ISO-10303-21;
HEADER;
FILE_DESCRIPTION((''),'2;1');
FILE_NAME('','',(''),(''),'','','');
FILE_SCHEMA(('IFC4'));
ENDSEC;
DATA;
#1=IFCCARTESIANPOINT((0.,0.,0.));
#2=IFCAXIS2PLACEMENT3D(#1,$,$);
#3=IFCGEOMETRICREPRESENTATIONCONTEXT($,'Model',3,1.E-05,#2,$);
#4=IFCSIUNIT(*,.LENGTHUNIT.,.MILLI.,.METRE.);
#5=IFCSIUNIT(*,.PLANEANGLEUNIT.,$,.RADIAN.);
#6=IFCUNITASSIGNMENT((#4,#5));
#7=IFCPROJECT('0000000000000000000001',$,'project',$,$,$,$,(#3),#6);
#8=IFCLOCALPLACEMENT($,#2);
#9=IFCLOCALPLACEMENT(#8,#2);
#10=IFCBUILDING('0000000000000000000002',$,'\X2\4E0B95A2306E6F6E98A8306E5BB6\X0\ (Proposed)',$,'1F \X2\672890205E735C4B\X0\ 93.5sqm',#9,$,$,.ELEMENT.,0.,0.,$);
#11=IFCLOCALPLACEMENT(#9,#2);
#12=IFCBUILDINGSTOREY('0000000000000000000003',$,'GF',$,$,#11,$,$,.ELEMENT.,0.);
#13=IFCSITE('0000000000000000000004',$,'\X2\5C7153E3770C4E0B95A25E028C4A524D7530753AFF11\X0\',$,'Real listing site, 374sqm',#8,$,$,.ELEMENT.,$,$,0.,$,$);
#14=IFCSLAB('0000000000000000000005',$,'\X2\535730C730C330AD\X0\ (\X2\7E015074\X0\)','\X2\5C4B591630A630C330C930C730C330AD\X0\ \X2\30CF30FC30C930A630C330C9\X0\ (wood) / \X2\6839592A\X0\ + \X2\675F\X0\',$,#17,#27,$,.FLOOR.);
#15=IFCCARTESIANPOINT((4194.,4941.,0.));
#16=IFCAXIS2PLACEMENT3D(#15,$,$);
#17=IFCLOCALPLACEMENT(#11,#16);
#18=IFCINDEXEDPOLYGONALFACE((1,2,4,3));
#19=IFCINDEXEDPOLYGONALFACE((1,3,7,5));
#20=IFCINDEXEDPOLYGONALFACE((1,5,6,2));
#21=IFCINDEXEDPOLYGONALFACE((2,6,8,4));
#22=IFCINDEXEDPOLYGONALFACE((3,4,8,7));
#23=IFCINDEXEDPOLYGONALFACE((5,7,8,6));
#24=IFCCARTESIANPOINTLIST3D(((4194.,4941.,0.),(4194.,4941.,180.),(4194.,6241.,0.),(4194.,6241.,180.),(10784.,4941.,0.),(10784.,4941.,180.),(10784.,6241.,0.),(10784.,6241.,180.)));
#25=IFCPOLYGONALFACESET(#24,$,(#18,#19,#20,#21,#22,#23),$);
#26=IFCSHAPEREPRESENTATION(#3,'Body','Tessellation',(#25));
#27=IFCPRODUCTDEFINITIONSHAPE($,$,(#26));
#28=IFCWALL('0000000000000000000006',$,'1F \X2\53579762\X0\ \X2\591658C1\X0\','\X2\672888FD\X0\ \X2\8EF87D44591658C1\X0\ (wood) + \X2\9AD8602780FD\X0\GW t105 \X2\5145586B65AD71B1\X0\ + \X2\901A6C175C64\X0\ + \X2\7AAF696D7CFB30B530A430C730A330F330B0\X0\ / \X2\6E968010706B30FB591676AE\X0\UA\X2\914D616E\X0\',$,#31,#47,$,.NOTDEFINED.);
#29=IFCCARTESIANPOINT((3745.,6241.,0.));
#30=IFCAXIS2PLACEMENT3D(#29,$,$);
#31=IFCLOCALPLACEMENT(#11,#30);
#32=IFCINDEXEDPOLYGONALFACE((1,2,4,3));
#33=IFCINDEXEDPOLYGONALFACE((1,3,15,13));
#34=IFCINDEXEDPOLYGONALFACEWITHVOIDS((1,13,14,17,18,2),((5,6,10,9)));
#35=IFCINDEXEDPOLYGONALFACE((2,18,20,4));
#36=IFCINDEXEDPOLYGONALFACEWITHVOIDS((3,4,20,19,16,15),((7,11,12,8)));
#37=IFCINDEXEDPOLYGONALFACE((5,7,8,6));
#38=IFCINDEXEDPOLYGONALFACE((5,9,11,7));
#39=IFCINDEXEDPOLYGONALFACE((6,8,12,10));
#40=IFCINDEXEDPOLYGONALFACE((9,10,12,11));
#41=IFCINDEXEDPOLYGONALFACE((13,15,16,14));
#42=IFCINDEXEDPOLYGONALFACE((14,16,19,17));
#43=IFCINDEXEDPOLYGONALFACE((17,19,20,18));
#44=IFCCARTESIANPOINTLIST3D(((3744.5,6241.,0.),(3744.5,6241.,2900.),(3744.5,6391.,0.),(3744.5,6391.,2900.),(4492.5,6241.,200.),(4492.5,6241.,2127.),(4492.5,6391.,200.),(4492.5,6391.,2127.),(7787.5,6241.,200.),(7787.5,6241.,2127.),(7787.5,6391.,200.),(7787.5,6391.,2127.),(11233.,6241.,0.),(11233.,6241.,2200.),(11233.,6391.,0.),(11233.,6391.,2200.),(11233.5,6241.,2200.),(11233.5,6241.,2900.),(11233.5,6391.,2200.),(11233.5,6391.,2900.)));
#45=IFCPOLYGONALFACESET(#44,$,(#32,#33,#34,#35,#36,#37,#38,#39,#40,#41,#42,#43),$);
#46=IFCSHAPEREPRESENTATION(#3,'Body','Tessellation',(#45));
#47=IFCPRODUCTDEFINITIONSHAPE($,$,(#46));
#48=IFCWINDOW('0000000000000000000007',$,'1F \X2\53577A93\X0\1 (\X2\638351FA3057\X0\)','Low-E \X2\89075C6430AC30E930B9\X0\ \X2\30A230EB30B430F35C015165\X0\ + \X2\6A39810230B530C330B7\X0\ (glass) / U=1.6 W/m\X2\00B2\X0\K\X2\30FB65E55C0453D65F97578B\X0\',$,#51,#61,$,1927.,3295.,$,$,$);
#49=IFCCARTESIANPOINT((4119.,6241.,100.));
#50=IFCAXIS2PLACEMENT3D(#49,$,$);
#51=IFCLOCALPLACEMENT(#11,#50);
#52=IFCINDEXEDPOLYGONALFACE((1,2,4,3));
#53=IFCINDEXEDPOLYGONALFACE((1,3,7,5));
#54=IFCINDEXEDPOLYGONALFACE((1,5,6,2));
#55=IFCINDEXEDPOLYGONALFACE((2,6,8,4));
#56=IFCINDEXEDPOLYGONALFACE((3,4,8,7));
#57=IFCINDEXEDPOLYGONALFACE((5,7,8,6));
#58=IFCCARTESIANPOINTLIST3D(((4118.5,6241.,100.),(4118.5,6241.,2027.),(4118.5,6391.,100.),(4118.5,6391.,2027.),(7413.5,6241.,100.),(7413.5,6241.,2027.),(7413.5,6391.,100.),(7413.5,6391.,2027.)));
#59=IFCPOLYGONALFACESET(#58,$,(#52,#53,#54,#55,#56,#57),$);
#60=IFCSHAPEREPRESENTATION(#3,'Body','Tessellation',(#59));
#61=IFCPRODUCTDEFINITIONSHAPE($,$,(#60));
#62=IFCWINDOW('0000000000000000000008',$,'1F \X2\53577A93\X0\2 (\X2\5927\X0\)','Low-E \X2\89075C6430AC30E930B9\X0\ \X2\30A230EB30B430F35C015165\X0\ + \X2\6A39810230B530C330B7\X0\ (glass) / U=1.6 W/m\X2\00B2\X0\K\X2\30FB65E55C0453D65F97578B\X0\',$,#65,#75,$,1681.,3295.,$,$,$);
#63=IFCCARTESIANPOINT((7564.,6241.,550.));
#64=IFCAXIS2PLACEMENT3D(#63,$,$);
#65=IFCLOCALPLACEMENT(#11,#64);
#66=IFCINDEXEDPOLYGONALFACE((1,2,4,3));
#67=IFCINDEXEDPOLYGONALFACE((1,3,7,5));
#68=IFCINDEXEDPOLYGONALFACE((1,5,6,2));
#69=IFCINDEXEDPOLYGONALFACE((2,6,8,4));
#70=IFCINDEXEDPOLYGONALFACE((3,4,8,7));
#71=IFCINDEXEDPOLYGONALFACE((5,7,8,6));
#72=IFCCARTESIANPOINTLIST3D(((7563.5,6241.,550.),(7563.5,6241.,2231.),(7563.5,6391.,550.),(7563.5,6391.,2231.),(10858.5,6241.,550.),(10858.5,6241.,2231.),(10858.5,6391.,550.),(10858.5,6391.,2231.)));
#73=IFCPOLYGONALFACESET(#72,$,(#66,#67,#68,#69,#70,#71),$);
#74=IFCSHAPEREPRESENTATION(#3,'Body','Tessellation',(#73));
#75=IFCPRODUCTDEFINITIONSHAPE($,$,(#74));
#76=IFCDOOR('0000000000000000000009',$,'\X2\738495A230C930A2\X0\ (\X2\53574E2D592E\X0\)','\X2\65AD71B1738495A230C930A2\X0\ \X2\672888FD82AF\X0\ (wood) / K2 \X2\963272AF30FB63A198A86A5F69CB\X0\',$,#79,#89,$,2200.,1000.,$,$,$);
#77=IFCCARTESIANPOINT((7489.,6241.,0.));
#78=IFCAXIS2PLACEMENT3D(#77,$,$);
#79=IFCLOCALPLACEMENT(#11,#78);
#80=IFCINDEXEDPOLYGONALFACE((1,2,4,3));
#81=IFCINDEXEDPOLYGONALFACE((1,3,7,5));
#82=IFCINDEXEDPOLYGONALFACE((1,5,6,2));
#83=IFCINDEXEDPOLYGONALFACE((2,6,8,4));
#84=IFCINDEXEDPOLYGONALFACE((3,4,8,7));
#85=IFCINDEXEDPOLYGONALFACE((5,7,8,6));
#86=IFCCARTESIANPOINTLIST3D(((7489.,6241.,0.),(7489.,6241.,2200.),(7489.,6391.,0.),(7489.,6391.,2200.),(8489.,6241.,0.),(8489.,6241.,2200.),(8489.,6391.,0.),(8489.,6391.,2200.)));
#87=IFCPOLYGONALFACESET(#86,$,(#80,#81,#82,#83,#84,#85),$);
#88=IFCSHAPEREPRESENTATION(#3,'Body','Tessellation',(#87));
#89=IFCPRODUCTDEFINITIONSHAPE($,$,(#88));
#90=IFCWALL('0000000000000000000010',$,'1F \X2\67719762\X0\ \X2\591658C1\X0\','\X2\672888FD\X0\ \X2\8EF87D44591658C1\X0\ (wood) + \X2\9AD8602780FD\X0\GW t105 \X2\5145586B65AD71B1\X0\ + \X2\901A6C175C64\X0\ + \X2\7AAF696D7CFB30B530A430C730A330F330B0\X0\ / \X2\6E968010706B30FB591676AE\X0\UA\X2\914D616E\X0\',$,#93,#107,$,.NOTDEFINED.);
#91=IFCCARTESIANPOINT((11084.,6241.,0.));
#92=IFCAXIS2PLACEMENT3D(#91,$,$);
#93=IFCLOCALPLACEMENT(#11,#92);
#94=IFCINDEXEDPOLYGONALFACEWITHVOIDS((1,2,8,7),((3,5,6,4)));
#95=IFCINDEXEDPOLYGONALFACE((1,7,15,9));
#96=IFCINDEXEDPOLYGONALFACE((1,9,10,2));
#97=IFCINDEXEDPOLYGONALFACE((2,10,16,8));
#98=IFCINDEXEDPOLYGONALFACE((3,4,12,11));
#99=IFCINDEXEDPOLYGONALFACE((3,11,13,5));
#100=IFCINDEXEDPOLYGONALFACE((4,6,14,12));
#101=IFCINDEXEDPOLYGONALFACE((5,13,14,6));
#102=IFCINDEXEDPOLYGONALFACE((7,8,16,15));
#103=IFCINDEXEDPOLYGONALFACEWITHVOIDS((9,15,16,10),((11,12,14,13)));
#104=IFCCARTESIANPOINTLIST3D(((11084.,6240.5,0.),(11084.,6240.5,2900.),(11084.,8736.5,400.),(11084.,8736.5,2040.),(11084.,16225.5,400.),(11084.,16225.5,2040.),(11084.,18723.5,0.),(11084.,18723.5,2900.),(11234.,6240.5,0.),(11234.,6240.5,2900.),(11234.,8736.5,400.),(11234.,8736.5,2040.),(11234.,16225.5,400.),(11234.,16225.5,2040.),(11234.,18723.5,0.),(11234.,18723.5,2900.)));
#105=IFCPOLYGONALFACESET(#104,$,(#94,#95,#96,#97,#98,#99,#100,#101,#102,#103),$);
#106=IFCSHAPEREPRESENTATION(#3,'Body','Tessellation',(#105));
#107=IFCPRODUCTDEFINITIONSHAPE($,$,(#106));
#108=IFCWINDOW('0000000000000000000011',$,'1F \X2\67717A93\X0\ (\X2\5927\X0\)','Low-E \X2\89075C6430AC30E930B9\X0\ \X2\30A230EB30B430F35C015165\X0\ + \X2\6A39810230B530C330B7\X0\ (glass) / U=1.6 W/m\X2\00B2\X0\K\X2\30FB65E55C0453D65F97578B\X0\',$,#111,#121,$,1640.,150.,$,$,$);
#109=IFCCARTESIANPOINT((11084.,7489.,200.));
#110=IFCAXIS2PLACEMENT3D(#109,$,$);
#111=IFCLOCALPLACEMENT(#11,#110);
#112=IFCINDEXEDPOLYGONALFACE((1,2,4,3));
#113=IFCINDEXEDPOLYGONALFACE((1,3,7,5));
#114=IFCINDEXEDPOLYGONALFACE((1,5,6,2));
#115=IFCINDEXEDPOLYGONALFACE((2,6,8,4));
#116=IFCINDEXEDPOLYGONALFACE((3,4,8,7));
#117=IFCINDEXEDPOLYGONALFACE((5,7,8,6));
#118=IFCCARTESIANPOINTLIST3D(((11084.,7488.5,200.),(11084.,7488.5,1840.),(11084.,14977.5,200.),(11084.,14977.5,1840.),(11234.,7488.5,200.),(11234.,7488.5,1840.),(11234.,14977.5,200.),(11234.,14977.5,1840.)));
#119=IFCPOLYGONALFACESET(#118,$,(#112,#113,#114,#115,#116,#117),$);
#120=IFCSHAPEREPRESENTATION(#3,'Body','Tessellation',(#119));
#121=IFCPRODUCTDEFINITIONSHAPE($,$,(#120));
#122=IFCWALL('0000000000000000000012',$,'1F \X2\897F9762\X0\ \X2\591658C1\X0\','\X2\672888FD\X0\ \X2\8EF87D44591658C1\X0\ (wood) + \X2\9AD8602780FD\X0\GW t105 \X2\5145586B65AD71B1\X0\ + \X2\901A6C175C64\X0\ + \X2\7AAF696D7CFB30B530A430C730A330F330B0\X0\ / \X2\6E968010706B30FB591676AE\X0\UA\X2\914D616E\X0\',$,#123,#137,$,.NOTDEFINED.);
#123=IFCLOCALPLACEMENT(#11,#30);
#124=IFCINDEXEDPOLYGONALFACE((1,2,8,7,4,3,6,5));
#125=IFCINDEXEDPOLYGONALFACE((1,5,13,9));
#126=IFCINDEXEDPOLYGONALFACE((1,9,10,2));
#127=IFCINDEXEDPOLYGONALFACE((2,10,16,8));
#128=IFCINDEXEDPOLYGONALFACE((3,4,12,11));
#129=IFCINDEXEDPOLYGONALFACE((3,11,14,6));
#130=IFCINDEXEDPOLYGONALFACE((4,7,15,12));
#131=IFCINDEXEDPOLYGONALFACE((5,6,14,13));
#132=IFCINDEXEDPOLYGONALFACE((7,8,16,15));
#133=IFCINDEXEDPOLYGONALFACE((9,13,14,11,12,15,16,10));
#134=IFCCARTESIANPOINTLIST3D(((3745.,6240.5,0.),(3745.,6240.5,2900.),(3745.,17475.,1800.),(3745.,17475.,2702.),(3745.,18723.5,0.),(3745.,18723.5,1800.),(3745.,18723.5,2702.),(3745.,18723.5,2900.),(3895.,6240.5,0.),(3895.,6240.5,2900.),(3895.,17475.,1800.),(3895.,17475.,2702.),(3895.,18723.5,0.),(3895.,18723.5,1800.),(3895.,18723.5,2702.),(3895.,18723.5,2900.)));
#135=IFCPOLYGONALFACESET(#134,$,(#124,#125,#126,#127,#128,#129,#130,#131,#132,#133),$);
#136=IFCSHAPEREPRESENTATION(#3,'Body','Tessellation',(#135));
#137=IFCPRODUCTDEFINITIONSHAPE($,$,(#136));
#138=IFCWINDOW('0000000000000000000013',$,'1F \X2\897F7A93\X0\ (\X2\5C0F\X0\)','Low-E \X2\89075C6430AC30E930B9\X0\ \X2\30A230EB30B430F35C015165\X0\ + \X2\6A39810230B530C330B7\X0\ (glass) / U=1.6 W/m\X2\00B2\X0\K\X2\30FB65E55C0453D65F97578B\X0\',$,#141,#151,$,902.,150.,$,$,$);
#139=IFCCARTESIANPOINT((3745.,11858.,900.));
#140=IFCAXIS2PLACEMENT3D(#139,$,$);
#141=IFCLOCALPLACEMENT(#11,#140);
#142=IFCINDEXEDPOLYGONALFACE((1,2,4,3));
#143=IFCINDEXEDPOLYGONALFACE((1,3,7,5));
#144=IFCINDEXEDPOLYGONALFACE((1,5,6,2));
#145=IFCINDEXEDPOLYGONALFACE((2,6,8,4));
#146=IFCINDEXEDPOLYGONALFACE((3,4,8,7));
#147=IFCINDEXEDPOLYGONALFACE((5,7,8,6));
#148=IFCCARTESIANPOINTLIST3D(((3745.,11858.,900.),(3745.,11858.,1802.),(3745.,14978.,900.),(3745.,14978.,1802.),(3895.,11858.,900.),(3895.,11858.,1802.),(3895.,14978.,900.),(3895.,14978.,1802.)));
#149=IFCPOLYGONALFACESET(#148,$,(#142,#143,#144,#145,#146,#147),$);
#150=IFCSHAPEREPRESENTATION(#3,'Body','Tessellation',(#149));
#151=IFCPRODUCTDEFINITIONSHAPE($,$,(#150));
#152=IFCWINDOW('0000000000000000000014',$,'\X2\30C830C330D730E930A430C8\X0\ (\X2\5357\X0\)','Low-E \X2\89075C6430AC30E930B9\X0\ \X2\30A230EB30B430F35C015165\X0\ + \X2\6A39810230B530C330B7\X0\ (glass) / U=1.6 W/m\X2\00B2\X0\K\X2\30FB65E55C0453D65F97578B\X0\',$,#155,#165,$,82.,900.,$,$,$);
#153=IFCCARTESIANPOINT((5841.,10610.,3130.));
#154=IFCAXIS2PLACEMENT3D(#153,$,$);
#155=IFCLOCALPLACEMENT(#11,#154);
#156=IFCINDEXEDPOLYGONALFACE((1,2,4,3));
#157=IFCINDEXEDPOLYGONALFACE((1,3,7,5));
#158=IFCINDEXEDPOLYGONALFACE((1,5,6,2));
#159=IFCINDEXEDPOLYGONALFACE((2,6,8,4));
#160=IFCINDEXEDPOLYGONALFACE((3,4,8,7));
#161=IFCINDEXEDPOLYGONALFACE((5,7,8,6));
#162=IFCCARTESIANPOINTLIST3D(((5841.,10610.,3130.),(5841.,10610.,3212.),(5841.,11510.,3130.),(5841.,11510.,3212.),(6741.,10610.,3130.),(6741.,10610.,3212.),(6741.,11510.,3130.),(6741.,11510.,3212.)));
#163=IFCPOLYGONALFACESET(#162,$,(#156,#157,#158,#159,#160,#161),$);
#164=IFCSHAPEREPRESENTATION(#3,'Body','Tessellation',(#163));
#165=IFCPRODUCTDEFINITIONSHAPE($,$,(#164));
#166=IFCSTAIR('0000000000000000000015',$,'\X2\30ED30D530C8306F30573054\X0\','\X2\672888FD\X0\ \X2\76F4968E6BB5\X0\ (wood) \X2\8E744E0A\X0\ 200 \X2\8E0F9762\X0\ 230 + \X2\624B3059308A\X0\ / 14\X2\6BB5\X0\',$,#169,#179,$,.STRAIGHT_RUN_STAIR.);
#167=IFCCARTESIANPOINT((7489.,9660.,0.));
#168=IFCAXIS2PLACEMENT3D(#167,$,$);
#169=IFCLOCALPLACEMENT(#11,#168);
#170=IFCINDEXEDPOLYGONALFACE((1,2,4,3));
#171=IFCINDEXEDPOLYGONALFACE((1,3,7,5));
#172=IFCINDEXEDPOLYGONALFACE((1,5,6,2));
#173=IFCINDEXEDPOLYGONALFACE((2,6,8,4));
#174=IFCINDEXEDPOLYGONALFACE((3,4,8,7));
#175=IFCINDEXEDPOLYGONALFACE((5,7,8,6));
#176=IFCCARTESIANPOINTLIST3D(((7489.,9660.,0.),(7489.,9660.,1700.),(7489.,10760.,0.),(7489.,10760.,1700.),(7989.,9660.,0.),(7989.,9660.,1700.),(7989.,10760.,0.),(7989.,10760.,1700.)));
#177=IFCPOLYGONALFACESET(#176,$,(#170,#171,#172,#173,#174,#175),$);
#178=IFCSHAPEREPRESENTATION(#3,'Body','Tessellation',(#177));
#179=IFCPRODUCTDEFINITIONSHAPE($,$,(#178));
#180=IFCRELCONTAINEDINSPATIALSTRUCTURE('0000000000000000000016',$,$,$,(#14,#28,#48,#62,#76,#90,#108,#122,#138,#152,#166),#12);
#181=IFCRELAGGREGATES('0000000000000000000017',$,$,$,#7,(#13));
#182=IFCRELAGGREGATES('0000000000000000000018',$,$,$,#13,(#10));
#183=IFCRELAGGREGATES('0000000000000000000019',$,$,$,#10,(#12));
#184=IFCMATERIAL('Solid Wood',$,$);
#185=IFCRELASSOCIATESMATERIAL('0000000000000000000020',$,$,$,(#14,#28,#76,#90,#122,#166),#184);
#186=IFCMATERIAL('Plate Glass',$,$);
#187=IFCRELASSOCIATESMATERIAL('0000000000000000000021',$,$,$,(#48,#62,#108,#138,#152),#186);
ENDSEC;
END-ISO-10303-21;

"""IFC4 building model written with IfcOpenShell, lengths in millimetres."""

from ifc_helpers import new_model, si_unit, frame, frame_2d, origin, place, context, project, spatial, rectangle, extrude, material, element, fill, save


model = new_model("IFC4")

# Units and contexts
model_context = context("Model", 3, precision=1e-05, world=origin())
ifc_project = project(units=[si_unit("LENGTHUNIT", "METRE", prefix="MILLI"), si_unit("PLANEANGLEUNIT", "RADIAN")], contexts=[model_context])

# Site, building, storey
site_placement = place(None, origin())
site = spatial("IfcSite", under=ifc_project, at=site_placement, Name="山口県下関市豊前田町１", ObjectType="Real listing site, 374sqm", CompositionType="ELEMENT", RefElevation=0.0)
building_placement = place(site_placement, origin())
building = spatial("IfcBuilding", under=site, at=building_placement, Name="下関の潮風の家 (Proposed)", ObjectType="1F 木造平屋 93.5sqm", CompositionType="ELEMENT", ElevationOfRefHeight=0.0, ElevationOfTerrain=0.0)
storey_placement = place(building_placement, origin())
storey = spatial("IfcBuildingStorey", under=building, at=storey_placement, Name="GF", CompositionType="ELEMENT", Elevation=0.0)

# Slab
ifc_material_1 = material(Name="Solid Wood")
slab_1_placement = place(storey_placement, frame((4194.0, 4941.0, 0.0)))
element("IfcSlab", 1, at=slab_1_placement, inside=storey, material=ifc_material_1, Name="南デッキ (縁側)", Description="屋外ウッドデッキ ハードウッド (wood) / 根太 + 束", PredefinedType="FLOOR", context=model_context, shape_type="SweptSolid", body=[
    extrude(rectangle(XDim=6590.0, YDim=1300.0, at=frame_2d((3295.0, 650.0))), frame((4194.0, 4941.0, 0.0)), (0.0, 0.0, 1.0), 180.0),
])

# Wall, openings, windows, door
wall_1_placement = place(storey_placement, frame((3745.0, 6241.0, 0.0)))
wall_1 = element("IfcWall", 2, at=wall_1_placement, inside=storey, material=ifc_material_1, Name="1F 南面 外壁", Description="木製 軸組外壁 (wood) + 高性能GW t105 充填断熱 + 通気層 + 窯業系サイディング / 準耐火・外皮UA配慮", PredefinedType="NOTDEFINED", context=model_context, shape_type="SweptSolid", body=[
    extrude(rectangle(XDim=7489.0, YDim=150.0, at=frame_2d((3744.0, 75.0))), frame((3745.0, 6241.0, 0.0)), (0.0, 0.0, 1.0), 2900.0),
])
opening_1_placement = place(storey_placement, frame((4119.0, 6241.0, 100.0)))
opening_1 = element("IfcOpeningElement", 3, at=opening_1_placement, cuts=wall_1, PredefinedType="NOTDEFINED", context=model_context, shape_type="SweptSolid", body=[
    extrude(rectangle(XDim=3295.0, YDim=150.0, at=frame_2d((1647.0, 75.0))), frame((4119.0, 6241.0, 100.0)), (0.0, 0.0, 1.0), 1927.0),
])
opening_2_placement = place(storey_placement, frame((7564.0, 6241.0, 550.0)))
opening_2 = element("IfcOpeningElement", 4, at=opening_2_placement, cuts=wall_1, PredefinedType="NOTDEFINED", context=model_context, shape_type="SweptSolid", body=[
    extrude(rectangle(XDim=3295.0, YDim=150.0, at=frame_2d((1647.0, 75.0))), frame((7564.0, 6241.0, 550.0)), (0.0, 0.0, 1.0), 1681.0),
])
opening_3_placement = place(storey_placement, frame((7489.0, 6241.0, 0.0)))
opening_3 = element("IfcOpeningElement", 5, at=opening_3_placement, cuts=wall_1, PredefinedType="NOTDEFINED", context=model_context, shape_type="SweptSolid", body=[
    extrude(rectangle(XDim=1000.0, YDim=150.0, at=frame_2d((500.0, 75.0))), frame((7489.0, 6241.0, 0.0)), (0.0, 0.0, 1.0), 2200.0),
])
ifc_material_2 = material(Name="Plate Glass")
window_1_placement = place(storey_placement, frame((4119.0, 6241.0, 100.0)))
window_1 = element("IfcWindow", 6, at=window_1_placement, inside=storey, material=ifc_material_2, Name="1F 南窓1 (掃出し)", Description="Low-E 複層ガラス アルゴン封入 + 樹脂サッシ (glass) / U=1.6 W/m²K・日射取得型", OverallHeight=1927.0, OverallWidth=3295.0, context=model_context, shape_type="SweptSolid", body=[
    extrude(rectangle(XDim=3295.0, YDim=150.0, at=frame_2d((1647.0, 75.0))), frame((4119.0, 6241.0, 100.0)), (0.0, 0.0, 1.0), 1927.0),
])
fill(opening_1, window_1)
window_2_placement = place(storey_placement, frame((7564.0, 6241.0, 550.0)))
window_2 = element("IfcWindow", 7, at=window_2_placement, inside=storey, material=ifc_material_2, Name="1F 南窓2 (大)", Description="Low-E 複層ガラス アルゴン封入 + 樹脂サッシ (glass) / U=1.6 W/m²K・日射取得型", OverallHeight=1681.0, OverallWidth=3295.0, context=model_context, shape_type="SweptSolid", body=[
    extrude(rectangle(XDim=3295.0, YDim=150.0, at=frame_2d((1647.0, 75.0))), frame((7564.0, 6241.0, 550.0)), (0.0, 0.0, 1.0), 1681.0),
])
fill(opening_2, window_2)
door_placement = place(storey_placement, frame((7489.0, 6241.0, 0.0)))
door = element("IfcDoor", 8, at=door_placement, inside=storey, material=ifc_material_1, Name="玄関ドア (南中央)", Description="断熱玄関ドア 木製芯 (wood) / K2 防犯・採風機構", OverallHeight=2200.0, OverallWidth=1000.0, context=model_context, shape_type="SweptSolid", body=[
    extrude(rectangle(XDim=1000.0, YDim=150.0, at=frame_2d((500.0, 75.0))), frame((7489.0, 6241.0, 0.0)), (0.0, 0.0, 1.0), 2200.0),
])
fill(opening_3, door)

# Walls, openings, windows
wall_2_placement = place(storey_placement, frame((11084.0, 6241.0, 0.0)))
wall_2 = element("IfcWall", 9, at=wall_2_placement, inside=storey, material=ifc_material_1, Name="1F 東面 外壁", Description="木製 軸組外壁 (wood) + 高性能GW t105 充填断熱 + 通気層 + 窯業系サイディング / 準耐火・外皮UA配慮", PredefinedType="NOTDEFINED", context=model_context, shape_type="SweptSolid", body=[
    extrude(rectangle(XDim=150.0, YDim=12483.0, at=frame_2d((75.0, 6241.0))), frame((11084.0, 6241.0, 0.0)), (0.0, 0.0, 1.0), 2900.0),
])
opening_4_placement = place(storey_placement, frame((11084.0, 7489.0, 200.0)))
opening_4 = element("IfcOpeningElement", 10, at=opening_4_placement, cuts=wall_2, PredefinedType="NOTDEFINED", context=model_context, shape_type="SweptSolid", body=[
    extrude(rectangle(XDim=150.0, YDim=7489.0, at=frame_2d((75.0, 3744.0))), frame((11084.0, 7489.0, 200.0)), (0.0, 0.0, 1.0), 1640.0),
])
window_3_placement = place(storey_placement, frame((11084.0, 7489.0, 200.0)))
window_3 = element("IfcWindow", 11, at=window_3_placement, inside=storey, material=ifc_material_2, Name="1F 東窓 (大)", Description="Low-E 複層ガラス アルゴン封入 + 樹脂サッシ (glass) / U=1.6 W/m²K・日射取得型", OverallHeight=1640.0, OverallWidth=150.0, context=model_context, shape_type="SweptSolid", body=[
    extrude(rectangle(XDim=150.0, YDim=7489.0, at=frame_2d((75.0, 3744.0))), frame((11084.0, 7489.0, 200.0)), (0.0, 0.0, 1.0), 1640.0),
])
fill(opening_4, window_3)
wall_3_placement = place(storey_placement, frame((3745.0, 6241.0, 0.0)))
wall_3 = element("IfcWall", 12, at=wall_3_placement, inside=storey, material=ifc_material_1, Name="1F 西面 外壁", Description="木製 軸組外壁 (wood) + 高性能GW t105 充填断熱 + 通気層 + 窯業系サイディング / 準耐火・外皮UA配慮", PredefinedType="NOTDEFINED", context=model_context, shape_type="SweptSolid", body=[
    extrude(rectangle(XDim=150.0, YDim=12483.0, at=frame_2d((75.0, 6241.0))), frame((3745.0, 6241.0, 0.0)), (0.0, 0.0, 1.0), 2900.0),
])
opening_5_placement = place(storey_placement, frame((3745.0, 11858.0, 900.0)))
opening_5 = element("IfcOpeningElement", 13, at=opening_5_placement, cuts=wall_3, PredefinedType="NOTDEFINED", context=model_context, shape_type="SweptSolid", body=[
    extrude(rectangle(XDim=150.0, YDim=3120.0, at=frame_2d((75.0, 1560.0))), frame((3745.0, 11858.0, 900.0)), (0.0, 0.0, 1.0), 902.0),
])
window_4_placement = place(storey_placement, frame((3745.0, 11858.0, 900.0)))
window_4 = element("IfcWindow", 14, at=window_4_placement, inside=storey, material=ifc_material_2, Name="1F 西窓 (小)", Description="Low-E 複層ガラス アルゴン封入 + 樹脂サッシ (glass) / U=1.6 W/m²K・日射取得型", OverallHeight=902.0, OverallWidth=150.0, context=model_context, shape_type="SweptSolid", body=[
    extrude(rectangle(XDim=150.0, YDim=3120.0, at=frame_2d((75.0, 1560.0))), frame((3745.0, 11858.0, 900.0)), (0.0, 0.0, 1.0), 902.0),
])
fill(opening_5, window_4)

# Window
window_5_placement = place(storey_placement, frame((5841.0, 10610.0, 3130.0)))
element("IfcWindow", 15, at=window_5_placement, inside=storey, material=ifc_material_2, Name="トップライト (南)", Description="Low-E 複層ガラス アルゴン封入 + 樹脂サッシ (glass) / U=1.6 W/m²K・日射取得型", OverallHeight=82.0, OverallWidth=900.0, context=model_context, shape_type="SweptSolid", body=[
    extrude(rectangle(XDim=900.0, YDim=900.0, at=frame_2d((450.0, 450.0))), frame((5841.0, 10610.0, 3130.0)), (0.0, 0.0, 1.0), 82.0),
])

# Stair
stair_placement = place(storey_placement, frame((7489.0, 9660.0, 0.0)))
element("IfcStair", 16, at=stair_placement, inside=storey, material=ifc_material_1, Name="ロフトはしご", Description="木製 直階段 (wood) 蹴上 200 踏面 230 + 手すり / 14段", PredefinedType="STRAIGHT_RUN_STAIR", context=model_context, shape_type="SweptSolid", body=[
    extrude(rectangle(XDim=500.0, YDim=1100.0, at=frame_2d((250.0, 550.0))), frame((7489.0, 9660.0, 0.0)), (0.0, 0.0, 1.0), 1700.0),
])

save(model, "model.ifc")
